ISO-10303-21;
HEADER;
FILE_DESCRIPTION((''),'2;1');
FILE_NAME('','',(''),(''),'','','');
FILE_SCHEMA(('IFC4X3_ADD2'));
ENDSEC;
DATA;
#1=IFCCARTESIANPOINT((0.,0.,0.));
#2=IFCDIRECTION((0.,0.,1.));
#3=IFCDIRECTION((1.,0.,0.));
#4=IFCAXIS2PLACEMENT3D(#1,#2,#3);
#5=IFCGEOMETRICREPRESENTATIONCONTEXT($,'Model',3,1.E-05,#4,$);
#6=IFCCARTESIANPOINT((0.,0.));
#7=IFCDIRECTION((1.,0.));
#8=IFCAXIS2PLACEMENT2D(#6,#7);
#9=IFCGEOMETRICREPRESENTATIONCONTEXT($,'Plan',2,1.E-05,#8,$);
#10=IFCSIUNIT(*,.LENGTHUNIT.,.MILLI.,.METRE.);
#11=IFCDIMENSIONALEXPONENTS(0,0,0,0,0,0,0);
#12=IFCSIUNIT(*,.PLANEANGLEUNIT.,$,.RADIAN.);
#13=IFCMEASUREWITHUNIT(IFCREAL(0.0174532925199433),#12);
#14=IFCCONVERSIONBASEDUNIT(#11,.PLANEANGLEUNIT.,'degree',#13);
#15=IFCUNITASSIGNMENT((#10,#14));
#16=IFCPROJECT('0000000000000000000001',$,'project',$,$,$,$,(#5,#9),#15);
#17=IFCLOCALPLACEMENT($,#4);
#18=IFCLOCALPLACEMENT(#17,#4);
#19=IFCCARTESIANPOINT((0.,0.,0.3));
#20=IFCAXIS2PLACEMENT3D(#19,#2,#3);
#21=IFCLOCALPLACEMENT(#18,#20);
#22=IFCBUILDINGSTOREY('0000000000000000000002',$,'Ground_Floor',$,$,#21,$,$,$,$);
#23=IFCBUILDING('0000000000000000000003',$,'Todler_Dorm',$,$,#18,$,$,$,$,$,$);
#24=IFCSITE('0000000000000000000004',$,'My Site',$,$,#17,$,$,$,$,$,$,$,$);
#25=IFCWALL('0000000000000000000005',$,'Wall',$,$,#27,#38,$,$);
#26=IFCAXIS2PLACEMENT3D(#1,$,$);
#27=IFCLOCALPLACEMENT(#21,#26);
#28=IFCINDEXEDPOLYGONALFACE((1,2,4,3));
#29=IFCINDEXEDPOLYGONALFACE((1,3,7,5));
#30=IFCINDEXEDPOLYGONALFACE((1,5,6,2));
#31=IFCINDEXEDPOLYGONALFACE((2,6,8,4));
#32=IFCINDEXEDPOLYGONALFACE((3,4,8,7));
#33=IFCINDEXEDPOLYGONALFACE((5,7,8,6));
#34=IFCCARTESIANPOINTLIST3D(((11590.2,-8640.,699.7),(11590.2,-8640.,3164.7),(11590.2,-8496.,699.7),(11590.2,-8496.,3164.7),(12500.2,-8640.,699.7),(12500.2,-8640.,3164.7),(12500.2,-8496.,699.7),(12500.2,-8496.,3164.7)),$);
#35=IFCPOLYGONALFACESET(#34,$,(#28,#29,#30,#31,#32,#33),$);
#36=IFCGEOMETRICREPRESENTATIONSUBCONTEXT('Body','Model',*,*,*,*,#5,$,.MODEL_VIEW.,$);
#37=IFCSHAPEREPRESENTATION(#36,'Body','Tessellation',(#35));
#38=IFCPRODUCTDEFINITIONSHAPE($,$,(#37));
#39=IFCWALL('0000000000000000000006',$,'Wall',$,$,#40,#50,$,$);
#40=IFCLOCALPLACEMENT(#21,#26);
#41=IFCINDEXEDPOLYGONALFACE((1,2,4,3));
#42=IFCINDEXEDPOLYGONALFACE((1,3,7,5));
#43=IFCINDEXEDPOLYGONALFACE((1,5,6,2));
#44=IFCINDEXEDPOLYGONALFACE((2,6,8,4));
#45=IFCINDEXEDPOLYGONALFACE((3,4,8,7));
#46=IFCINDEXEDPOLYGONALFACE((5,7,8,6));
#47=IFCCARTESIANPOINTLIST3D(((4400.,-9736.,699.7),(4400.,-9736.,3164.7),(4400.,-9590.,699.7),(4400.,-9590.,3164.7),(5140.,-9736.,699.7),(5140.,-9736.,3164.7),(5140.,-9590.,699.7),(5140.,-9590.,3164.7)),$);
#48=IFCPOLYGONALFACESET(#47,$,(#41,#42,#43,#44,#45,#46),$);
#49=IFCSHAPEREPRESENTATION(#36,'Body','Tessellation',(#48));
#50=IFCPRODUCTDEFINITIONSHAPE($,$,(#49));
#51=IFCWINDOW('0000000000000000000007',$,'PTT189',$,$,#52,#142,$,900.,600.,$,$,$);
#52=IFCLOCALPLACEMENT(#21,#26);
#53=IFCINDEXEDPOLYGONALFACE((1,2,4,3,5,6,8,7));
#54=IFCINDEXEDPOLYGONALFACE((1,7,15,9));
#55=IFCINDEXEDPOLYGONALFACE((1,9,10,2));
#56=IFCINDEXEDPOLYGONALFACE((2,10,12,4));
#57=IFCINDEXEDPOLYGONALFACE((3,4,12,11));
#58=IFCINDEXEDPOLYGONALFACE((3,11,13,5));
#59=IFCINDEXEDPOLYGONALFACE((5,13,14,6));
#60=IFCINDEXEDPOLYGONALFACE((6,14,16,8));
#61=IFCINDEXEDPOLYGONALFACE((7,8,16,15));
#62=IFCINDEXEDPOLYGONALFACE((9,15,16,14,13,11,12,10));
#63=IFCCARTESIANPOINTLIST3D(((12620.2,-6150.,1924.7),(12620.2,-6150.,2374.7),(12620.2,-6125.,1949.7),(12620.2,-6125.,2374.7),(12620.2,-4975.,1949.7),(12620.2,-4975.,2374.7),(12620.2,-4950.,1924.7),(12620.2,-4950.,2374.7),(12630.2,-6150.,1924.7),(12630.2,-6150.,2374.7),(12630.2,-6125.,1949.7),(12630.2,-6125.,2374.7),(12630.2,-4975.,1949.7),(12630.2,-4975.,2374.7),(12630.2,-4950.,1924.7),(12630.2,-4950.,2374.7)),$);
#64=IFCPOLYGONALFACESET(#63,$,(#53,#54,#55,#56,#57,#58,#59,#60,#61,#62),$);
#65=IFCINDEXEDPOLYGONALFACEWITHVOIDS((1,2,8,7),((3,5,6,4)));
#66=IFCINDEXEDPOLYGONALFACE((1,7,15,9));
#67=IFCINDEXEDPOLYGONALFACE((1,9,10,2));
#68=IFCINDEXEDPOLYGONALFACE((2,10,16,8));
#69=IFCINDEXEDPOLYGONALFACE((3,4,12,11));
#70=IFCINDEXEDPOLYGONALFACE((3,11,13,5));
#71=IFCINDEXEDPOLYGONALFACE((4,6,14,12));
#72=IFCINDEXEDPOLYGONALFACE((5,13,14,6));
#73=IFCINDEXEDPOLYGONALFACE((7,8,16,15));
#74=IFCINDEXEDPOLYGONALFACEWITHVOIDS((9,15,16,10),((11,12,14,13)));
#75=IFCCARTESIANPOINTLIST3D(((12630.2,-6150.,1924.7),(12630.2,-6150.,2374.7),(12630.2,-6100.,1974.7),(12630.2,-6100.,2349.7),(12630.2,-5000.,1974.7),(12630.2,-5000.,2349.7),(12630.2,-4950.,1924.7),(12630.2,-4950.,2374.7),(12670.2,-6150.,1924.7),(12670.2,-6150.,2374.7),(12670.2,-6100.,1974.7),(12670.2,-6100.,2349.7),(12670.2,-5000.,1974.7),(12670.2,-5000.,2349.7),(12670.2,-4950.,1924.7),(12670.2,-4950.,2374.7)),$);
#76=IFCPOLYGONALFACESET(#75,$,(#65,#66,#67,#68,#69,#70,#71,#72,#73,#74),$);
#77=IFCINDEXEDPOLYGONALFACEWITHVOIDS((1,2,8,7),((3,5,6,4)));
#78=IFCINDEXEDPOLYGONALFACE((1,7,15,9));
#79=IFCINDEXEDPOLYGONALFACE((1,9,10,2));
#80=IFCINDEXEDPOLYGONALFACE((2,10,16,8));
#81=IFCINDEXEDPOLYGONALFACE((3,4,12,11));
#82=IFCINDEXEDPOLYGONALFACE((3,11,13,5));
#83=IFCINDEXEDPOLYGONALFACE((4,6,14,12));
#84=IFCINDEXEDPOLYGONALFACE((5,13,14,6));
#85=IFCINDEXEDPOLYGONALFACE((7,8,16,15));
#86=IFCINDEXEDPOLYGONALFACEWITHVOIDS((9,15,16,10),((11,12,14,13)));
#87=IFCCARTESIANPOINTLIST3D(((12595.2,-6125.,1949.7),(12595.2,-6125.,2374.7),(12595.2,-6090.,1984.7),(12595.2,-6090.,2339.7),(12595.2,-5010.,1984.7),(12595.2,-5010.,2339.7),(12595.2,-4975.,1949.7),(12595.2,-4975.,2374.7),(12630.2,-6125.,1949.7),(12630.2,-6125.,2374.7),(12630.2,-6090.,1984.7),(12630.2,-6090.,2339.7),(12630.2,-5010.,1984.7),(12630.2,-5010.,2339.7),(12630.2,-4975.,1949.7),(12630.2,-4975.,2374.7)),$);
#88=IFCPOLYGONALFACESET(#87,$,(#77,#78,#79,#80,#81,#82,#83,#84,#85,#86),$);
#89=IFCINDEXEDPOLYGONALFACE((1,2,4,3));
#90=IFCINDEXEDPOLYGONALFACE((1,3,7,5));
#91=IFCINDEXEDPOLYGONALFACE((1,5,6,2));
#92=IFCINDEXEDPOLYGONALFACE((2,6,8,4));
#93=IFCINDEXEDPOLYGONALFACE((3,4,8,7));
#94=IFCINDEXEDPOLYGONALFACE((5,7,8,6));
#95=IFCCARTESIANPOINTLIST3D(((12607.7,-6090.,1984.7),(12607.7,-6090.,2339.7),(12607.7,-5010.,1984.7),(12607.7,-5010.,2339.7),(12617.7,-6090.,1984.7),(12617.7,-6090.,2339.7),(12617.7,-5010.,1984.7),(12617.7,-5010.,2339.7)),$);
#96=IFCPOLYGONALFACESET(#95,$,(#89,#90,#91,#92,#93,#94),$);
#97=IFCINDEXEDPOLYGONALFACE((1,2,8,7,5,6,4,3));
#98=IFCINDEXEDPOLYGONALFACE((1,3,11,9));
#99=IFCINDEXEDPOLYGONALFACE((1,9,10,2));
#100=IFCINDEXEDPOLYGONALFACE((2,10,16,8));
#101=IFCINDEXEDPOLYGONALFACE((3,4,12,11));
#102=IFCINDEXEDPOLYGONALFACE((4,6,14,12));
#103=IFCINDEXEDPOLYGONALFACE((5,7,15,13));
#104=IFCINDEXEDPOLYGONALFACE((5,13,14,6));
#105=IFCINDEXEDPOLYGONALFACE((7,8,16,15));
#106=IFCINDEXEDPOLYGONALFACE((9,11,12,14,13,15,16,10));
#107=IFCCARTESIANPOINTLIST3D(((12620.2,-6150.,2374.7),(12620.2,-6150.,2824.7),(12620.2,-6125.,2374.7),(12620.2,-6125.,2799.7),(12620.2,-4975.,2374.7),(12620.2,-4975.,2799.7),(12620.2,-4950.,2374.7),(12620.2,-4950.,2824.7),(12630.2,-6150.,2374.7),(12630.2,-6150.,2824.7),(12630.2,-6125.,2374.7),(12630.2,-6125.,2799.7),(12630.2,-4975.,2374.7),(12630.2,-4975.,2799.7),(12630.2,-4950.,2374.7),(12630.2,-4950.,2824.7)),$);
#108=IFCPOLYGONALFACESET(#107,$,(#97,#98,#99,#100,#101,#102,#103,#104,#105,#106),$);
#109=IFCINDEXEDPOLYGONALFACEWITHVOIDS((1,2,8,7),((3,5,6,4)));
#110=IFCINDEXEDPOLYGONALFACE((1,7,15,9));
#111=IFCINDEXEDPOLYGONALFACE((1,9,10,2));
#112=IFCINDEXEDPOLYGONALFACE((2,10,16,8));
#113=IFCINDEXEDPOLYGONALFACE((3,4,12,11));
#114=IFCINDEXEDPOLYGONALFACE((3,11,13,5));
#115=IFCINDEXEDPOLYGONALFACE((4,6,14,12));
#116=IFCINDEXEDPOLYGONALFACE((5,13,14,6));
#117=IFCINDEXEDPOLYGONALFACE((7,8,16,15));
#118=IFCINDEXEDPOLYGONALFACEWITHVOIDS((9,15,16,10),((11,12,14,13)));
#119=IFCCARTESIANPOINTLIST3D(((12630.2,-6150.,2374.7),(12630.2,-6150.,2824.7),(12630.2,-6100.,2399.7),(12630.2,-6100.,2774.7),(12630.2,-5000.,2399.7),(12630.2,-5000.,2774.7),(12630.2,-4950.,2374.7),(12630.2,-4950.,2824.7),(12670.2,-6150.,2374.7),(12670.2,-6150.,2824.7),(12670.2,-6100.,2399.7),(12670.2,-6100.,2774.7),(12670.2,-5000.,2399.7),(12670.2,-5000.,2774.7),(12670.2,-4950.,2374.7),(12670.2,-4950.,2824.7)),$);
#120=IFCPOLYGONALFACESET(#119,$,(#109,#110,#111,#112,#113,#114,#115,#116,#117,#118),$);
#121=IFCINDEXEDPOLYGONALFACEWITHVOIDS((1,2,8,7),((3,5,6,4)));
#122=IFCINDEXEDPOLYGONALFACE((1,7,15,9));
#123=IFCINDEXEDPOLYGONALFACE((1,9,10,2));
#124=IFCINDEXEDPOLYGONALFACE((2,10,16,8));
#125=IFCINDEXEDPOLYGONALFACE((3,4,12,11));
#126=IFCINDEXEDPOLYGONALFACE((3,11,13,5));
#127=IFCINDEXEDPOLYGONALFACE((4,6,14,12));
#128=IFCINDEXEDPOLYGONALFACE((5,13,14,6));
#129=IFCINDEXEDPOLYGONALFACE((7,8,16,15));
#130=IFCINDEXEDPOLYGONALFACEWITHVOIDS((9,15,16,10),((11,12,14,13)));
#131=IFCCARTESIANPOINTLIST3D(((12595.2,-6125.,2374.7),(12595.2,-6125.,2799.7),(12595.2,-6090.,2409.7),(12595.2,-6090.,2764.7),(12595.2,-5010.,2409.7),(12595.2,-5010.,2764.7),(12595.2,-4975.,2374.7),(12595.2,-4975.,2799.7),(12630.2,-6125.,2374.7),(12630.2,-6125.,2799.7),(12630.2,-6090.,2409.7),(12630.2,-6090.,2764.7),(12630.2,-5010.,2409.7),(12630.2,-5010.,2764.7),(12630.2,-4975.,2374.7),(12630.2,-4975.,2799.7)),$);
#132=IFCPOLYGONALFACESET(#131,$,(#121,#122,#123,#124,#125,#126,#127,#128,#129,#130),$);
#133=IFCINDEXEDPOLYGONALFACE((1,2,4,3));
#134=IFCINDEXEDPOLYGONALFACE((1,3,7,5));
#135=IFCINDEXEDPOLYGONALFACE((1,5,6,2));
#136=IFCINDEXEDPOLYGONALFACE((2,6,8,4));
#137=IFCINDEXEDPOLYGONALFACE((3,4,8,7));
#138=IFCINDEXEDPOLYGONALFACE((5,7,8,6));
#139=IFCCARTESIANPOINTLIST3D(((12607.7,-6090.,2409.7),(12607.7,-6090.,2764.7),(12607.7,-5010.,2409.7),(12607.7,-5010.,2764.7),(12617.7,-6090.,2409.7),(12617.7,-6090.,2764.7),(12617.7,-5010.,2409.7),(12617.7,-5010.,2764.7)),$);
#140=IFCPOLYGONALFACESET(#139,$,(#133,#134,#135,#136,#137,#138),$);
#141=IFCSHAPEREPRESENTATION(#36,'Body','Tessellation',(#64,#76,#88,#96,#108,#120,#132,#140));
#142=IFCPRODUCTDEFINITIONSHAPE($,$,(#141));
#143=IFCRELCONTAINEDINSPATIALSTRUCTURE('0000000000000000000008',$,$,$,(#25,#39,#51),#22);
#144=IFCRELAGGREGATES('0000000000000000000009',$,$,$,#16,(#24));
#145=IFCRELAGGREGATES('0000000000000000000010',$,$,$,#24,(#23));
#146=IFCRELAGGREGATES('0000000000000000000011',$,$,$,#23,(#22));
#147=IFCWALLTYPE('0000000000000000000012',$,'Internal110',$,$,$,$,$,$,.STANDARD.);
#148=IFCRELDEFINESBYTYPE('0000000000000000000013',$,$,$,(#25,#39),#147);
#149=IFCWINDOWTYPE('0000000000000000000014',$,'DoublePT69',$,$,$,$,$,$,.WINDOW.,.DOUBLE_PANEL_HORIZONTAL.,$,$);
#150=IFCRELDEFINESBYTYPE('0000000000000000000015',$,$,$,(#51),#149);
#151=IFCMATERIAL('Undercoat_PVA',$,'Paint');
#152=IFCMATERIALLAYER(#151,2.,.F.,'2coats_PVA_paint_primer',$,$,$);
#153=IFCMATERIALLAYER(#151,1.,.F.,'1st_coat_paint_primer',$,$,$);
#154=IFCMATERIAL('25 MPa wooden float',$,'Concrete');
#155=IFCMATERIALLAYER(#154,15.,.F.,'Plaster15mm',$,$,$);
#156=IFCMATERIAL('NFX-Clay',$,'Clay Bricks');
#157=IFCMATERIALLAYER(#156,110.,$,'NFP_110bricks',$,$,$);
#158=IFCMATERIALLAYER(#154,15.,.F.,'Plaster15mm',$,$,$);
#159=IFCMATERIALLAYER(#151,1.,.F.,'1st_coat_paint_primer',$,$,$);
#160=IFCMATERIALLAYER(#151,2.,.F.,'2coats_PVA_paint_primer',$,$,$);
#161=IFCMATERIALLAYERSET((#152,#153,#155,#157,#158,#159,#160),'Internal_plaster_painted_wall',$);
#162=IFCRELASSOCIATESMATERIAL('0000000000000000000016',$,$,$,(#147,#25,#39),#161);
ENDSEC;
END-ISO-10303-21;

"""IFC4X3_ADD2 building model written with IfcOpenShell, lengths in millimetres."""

from ifc_helpers import new_model, entity, si_unit, converted_unit, frame, origin_with_axes, origin_2d_with_axis, place, context, subcontext, project, spatial, line, indexed_curve, outline, extrude, shape, source, transform, mapped, material, layer, layer_set, layer_usage, type_object, type_shapes, element, save


model = new_model("IFC4X3_ADD2")

# Units and contexts
model_context = context("Model", 3, precision=1e-05, world=origin_with_axes())
plan_context = context("Plan", 2, precision=1e-05, world=origin_2d_with_axis())
body_context_1 = subcontext(model_context, "Body", "Model", "MODEL_VIEW")
body_context_2 = subcontext(plan_context, "Body", "Plan", "PLAN_VIEW")
ifc_project = project(units=[si_unit("LENGTHUNIT", "METRE", prefix="MILLI"), converted_unit("PLANEANGLEUNIT", "degree", entity("IfcReal", 0.0174532925199433), si_unit("PLANEANGLEUNIT", "RADIAN"), dimensions=[0, 0, 0, 0, 0, 0, 0])], contexts=[model_context, plan_context])

# Site, building, storey
site_placement = place(None, origin_with_axes())
site = spatial("IfcSite", under=ifc_project, at=site_placement, Name="My Site")
building_placement = place(site_placement, origin_with_axes())
building = spatial("IfcBuilding", under=site, at=building_placement, Name="Todler_Dorm")
storey_placement = place(building_placement, frame((0.0, 0.0, 0.3), z_axis=(0.0, 0.0, 1.0), x_axis=(1.0, 0.0, 0.0)))
storey = spatial("IfcBuildingStorey", under=building, at=storey_placement, Name="Ground_Floor")

# Shared definitions
window_type_1 = type_object("IfcWindowType", Name="DoublePT69", PartitioningType="DOUBLE_PANEL_HORIZONTAL", PredefinedType="WINDOW")
shared_shape_1 = source(origin_with_axes(), body_context_1, "Body", "SweptSolid", [
    extrude(outline(indexed_curve([(1200.0, 450.0), (1200.0, 0.0), (0.0, 0.0), (0.0, 450.0), (25.0, 450.0), (25.0, 25.0), (1175.0, 25.0), (1175.0, 450.0)], segments=[line(1, 2, 3, 4, 5, 6, 7, 8, 1)])), frame((0.0, 90.0, 0.0), z_axis=(0.0, -1.0, 0.0), x_axis=(1.0, 0.0, 0.0)), (0.0, 0.0, -1.0), 10.0),
    extrude(outline(indexed_curve([(0.0, 0.0), (1200.0, 0.0), (1200.0, 450.0), (0.0, 450.0)], segments=[line(1, 2, 3, 4, 1)]), holes=[indexed_curve([(50.0, 50.0), (1150.0, 50.0), (1150.0, 425.0), (50.0, 425.0)], segments=[line(1, 2, 3, 4, 1)])]), frame((0.0, 50.0, 0.0), z_axis=(0.0, -1.0, 0.0), x_axis=(1.0, 0.0, 0.0)), (0.0, 0.0, -1.0), 40.0),
    extrude(outline(indexed_curve([(0.0, 0.0), (1150.0, 0.0), (1150.0, 425.0), (0.0, 425.0)], segments=[line(1, 2, 3, 4, 1)]), holes=[indexed_curve([(35.0, 35.0), (1115.0, 35.0), (1115.0, 390.0), (35.0, 390.0)], segments=[line(1, 2, 3, 4, 1)])]), frame((25.0, 90.0, 25.0), z_axis=(0.0, -1.0, 0.0), x_axis=(1.0, 0.0, 0.0)), (0.0, 0.0, -1.0), 35.0),
    extrude(outline(indexed_curve([(35.0, 35.0), (1115.0, 35.0), (1115.0, 390.0), (35.0, 390.0)], segments=[line(1, 2, 3, 4, 1)])), frame((25.0, 102.5, 25.0), z_axis=(0.0, -1.0, 0.0), x_axis=(1.0, 0.0, 0.0)), (0.0, 0.0, -1.0), 10.0),
    extrude(outline(indexed_curve([(0.0, 0.0), (0.0, 450.0), (1200.0, 450.0), (1200.0, 0.0), (1175.0, 0.0), (1175.0, 425.0), (25.0, 425.0), (25.0, 0.0)], segments=[line(1, 2, 3, 4, 5, 6, 7, 8, 1)])), frame((0.0, 90.0, 450.0), z_axis=(0.0, -1.0, 0.0), x_axis=(1.0, 0.0, 0.0)), (0.0, 0.0, -1.0), 10.0),
    extrude(outline(indexed_curve([(0.0, 0.0), (1200.0, 0.0), (1200.0, 450.0), (0.0, 450.0)], segments=[line(1, 2, 3, 4, 1)]), holes=[indexed_curve([(50.0, 25.0), (1150.0, 25.0), (1150.0, 400.0), (50.0, 400.0)], segments=[line(1, 2, 3, 4, 1)])]), frame((0.0, 50.0, 450.0), z_axis=(0.0, -1.0, 0.0), x_axis=(1.0, 0.0, 0.0)), (0.0, 0.0, -1.0), 40.0),
    extrude(outline(indexed_curve([(0.0, 0.0), (1150.0, 0.0), (1150.0, 425.0), (0.0, 425.0)], segments=[line(1, 2, 3, 4, 1)]), holes=[indexed_curve([(35.0, 35.0), (1115.0, 35.0), (1115.0, 390.0), (35.0, 390.0)], segments=[line(1, 2, 3, 4, 1)])]), frame((25.0, 90.0, 450.0), z_axis=(0.0, -1.0, 0.0), x_axis=(1.0, 0.0, 0.0)), (0.0, 0.0, -1.0), 35.0),
    extrude(outline(indexed_curve([(35.0, 35.0), (1115.0, 35.0), (1115.0, 390.0), (35.0, 390.0)], segments=[line(1, 2, 3, 4, 1)])), frame((25.0, 102.5, 450.0), z_axis=(0.0, -1.0, 0.0), x_axis=(1.0, 0.0, 0.0)), (0.0, 0.0, -1.0), 10.0),
])
shared_shape_2 = source(origin_with_axes(), body_context_2, "Body", "Curve2D", [
    entity("IfcIndexedPolyCurve", entity("IfcCartesianPointList2D", [[50.0, 50.0], [1150.0, 50.0]])),
    entity("IfcIndexedPolyCurve", entity("IfcCartesianPointList2D", [[0.0, 100.0], [25.0, 100.0], [25.0, 90.0], [50.0, 90.0], [50.0, 50.0], [0.0, 50.0]]), [entity("IfcLineIndex", [1, 2, 3, 4, 5, 6, 1])]),
    entity("IfcIndexedPolyCurve", entity("IfcCartesianPointList2D", [[1200.0, 100.0], [1175.0, 100.0], [1175.0, 90.0], [1150.0, 90.0], [1150.0, 50.0], [1200.0, 50.0]]), [entity("IfcLineIndex", [1, 2, 3, 4, 5, 6, 1])]),
    entity("IfcIndexedPolyCurve", entity("IfcCartesianPointList2D", [[25.0, 90.0], [60.0, 90.0], [60.0, 125.0], [25.0, 125.0]]), [entity("IfcLineIndex", [1, 2, 3, 4, 1])]),
    entity("IfcIndexedPolyCurve", entity("IfcCartesianPointList2D", [[1175.0, 90.0], [1140.0, 90.0], [1140.0, 125.0], [1175.0, 125.0]]), [entity("IfcLineIndex", [1, 2, 3, 4, 1])]),
    entity("IfcIndexedPolyCurve", entity("IfcCartesianPointList2D", [[60.0, 90.0], [1140.0, 90.0]])),
    entity("IfcIndexedPolyCurve", entity("IfcCartesianPointList2D", [[60.0, 125.0], [1140.0, 125.0]])),
    entity("IfcIndexedPolyCurve", entity("IfcCartesianPointList2D", [[60.0, 107.5], [1140.0, 107.5]])),
])
type_shapes(window_type_1, [shared_shape_1, shared_shape_2])

# Shared definitions
ifc_material_1 = material(Name="Undercoat_PVA", Category="Paint")
ifc_layer_1 = layer(ifc_material_1, 2.0, ventilated=False, Name="2coats_PVA_paint_primer")
ifc_layer_2 = layer(ifc_material_1, 1.0, ventilated=False, Name="1st_coat_paint_primer")
ifc_material_2 = material(Name="25 MPa wooden float", Category="Concrete")
ifc_layer_3 = layer(ifc_material_2, 15.0, ventilated=False, Name="Plaster15mm")
ifc_material_3 = material(Name="NFX-Clay", Category="Clay Bricks")
ifc_layer_4 = layer(ifc_material_3, 110.0, Name="NFP_110bricks")
ifc_layer_5 = layer(ifc_material_2, 15.0, ventilated=False, Name="Plaster15mm")
ifc_layer_6 = layer(ifc_material_1, 1.0, ventilated=False, Name="1st_coat_paint_primer")
ifc_layer_7 = layer(ifc_material_1, 2.0, ventilated=False, Name="2coats_PVA_paint_primer")
ifc_layer_set_1 = layer_set([ifc_layer_1, ifc_layer_2, ifc_layer_3, ifc_layer_4, ifc_layer_5, ifc_layer_6, ifc_layer_7], Name="Internal_plaster_painted_wall")
wall_type_1 = type_object("IfcWallType", Name="Internal110", PredefinedType="STANDARD", material=ifc_layer_set_1)

# Wall
ifc_layer_usage_1 = layer_usage(ifc_layer_set_1, "AXIS2", "POSITIVE", 0.0)
wall_1_placement = place(storey_placement, frame((11590.2, -8640.0, 699.7), z_axis=(0.0, 0.0, 1.0), x_axis=(1.0, 0.0, 0.0)))
element("IfcWall", 1, at=wall_1_placement, inside=storey, type_object=wall_type_1, material=ifc_layer_usage_1, Name="Wall", context=body_context_1, shape_type="SweptSolid", body=[
    extrude(outline(indexed_curve([(0.0, 0.0), (0.0, 144.0), (910.0, 144.0), (910.0, 0.0)], segments=[line(1, 2, 3, 4, 1)])), origin_with_axes(), (0.0, 0.0, 1.0), 2465.0),
])

# Wall
ifc_layer_usage_2 = layer_usage(ifc_layer_set_1, "AXIS2", "POSITIVE", 0.0)
wall_2_placement = place(storey_placement, frame((5140.0, -9590.0, 699.7), z_axis=(0.0, 0.0, 1.0), x_axis=(-1.0, 0.0, 0.0)))
element("IfcWall", 2, at=wall_2_placement, inside=storey, type_object=wall_type_1, material=ifc_layer_usage_2, Name="Wall", context=body_context_1, shape_type="SweptSolid", body=[
    extrude(outline(indexed_curve([(0.0, 0.0), (0.0, 146.0), (740.0, 146.0), (740.0, 0.0)], segments=[line(1, 2, 3, 4, 1)])), origin_with_axes(), (0.0, 0.0, 1.0), 2465.0),
])

# Window
window_1_placement = place(storey_placement, frame((12720.2, -6150.0, 1924.7), z_axis=(0.0, 0.0, 1.0), x_axis=(0.0, 1.0, 0.0)))
element("IfcWindow", 3, at=window_1_placement, inside=storey, type_object=window_type_1, Name="PTT189", OverallHeight=900.0, OverallWidth=600.0, shapes=[
    shape(body_context_1, "Body", "MappedRepresentation", [mapped(shared_shape_1, transform((0.0, 0.0, 0.0), x_axis=(1.0, 0.0, 0.0), y_axis=(0.0, 1.0, 0.0), z_axis=(0.0, 0.0, 1.0), scale=1.0))]),
    shape(body_context_2, "Body", "MappedRepresentation", [mapped(shared_shape_2, transform((0.0, 0.0, 0.0), x_axis=(1.0, 0.0, 0.0), y_axis=(0.0, 1.0, 0.0), z_axis=(0.0, 0.0, 1.0), scale=1.0))]),
])

save(model, "model.ifc")
